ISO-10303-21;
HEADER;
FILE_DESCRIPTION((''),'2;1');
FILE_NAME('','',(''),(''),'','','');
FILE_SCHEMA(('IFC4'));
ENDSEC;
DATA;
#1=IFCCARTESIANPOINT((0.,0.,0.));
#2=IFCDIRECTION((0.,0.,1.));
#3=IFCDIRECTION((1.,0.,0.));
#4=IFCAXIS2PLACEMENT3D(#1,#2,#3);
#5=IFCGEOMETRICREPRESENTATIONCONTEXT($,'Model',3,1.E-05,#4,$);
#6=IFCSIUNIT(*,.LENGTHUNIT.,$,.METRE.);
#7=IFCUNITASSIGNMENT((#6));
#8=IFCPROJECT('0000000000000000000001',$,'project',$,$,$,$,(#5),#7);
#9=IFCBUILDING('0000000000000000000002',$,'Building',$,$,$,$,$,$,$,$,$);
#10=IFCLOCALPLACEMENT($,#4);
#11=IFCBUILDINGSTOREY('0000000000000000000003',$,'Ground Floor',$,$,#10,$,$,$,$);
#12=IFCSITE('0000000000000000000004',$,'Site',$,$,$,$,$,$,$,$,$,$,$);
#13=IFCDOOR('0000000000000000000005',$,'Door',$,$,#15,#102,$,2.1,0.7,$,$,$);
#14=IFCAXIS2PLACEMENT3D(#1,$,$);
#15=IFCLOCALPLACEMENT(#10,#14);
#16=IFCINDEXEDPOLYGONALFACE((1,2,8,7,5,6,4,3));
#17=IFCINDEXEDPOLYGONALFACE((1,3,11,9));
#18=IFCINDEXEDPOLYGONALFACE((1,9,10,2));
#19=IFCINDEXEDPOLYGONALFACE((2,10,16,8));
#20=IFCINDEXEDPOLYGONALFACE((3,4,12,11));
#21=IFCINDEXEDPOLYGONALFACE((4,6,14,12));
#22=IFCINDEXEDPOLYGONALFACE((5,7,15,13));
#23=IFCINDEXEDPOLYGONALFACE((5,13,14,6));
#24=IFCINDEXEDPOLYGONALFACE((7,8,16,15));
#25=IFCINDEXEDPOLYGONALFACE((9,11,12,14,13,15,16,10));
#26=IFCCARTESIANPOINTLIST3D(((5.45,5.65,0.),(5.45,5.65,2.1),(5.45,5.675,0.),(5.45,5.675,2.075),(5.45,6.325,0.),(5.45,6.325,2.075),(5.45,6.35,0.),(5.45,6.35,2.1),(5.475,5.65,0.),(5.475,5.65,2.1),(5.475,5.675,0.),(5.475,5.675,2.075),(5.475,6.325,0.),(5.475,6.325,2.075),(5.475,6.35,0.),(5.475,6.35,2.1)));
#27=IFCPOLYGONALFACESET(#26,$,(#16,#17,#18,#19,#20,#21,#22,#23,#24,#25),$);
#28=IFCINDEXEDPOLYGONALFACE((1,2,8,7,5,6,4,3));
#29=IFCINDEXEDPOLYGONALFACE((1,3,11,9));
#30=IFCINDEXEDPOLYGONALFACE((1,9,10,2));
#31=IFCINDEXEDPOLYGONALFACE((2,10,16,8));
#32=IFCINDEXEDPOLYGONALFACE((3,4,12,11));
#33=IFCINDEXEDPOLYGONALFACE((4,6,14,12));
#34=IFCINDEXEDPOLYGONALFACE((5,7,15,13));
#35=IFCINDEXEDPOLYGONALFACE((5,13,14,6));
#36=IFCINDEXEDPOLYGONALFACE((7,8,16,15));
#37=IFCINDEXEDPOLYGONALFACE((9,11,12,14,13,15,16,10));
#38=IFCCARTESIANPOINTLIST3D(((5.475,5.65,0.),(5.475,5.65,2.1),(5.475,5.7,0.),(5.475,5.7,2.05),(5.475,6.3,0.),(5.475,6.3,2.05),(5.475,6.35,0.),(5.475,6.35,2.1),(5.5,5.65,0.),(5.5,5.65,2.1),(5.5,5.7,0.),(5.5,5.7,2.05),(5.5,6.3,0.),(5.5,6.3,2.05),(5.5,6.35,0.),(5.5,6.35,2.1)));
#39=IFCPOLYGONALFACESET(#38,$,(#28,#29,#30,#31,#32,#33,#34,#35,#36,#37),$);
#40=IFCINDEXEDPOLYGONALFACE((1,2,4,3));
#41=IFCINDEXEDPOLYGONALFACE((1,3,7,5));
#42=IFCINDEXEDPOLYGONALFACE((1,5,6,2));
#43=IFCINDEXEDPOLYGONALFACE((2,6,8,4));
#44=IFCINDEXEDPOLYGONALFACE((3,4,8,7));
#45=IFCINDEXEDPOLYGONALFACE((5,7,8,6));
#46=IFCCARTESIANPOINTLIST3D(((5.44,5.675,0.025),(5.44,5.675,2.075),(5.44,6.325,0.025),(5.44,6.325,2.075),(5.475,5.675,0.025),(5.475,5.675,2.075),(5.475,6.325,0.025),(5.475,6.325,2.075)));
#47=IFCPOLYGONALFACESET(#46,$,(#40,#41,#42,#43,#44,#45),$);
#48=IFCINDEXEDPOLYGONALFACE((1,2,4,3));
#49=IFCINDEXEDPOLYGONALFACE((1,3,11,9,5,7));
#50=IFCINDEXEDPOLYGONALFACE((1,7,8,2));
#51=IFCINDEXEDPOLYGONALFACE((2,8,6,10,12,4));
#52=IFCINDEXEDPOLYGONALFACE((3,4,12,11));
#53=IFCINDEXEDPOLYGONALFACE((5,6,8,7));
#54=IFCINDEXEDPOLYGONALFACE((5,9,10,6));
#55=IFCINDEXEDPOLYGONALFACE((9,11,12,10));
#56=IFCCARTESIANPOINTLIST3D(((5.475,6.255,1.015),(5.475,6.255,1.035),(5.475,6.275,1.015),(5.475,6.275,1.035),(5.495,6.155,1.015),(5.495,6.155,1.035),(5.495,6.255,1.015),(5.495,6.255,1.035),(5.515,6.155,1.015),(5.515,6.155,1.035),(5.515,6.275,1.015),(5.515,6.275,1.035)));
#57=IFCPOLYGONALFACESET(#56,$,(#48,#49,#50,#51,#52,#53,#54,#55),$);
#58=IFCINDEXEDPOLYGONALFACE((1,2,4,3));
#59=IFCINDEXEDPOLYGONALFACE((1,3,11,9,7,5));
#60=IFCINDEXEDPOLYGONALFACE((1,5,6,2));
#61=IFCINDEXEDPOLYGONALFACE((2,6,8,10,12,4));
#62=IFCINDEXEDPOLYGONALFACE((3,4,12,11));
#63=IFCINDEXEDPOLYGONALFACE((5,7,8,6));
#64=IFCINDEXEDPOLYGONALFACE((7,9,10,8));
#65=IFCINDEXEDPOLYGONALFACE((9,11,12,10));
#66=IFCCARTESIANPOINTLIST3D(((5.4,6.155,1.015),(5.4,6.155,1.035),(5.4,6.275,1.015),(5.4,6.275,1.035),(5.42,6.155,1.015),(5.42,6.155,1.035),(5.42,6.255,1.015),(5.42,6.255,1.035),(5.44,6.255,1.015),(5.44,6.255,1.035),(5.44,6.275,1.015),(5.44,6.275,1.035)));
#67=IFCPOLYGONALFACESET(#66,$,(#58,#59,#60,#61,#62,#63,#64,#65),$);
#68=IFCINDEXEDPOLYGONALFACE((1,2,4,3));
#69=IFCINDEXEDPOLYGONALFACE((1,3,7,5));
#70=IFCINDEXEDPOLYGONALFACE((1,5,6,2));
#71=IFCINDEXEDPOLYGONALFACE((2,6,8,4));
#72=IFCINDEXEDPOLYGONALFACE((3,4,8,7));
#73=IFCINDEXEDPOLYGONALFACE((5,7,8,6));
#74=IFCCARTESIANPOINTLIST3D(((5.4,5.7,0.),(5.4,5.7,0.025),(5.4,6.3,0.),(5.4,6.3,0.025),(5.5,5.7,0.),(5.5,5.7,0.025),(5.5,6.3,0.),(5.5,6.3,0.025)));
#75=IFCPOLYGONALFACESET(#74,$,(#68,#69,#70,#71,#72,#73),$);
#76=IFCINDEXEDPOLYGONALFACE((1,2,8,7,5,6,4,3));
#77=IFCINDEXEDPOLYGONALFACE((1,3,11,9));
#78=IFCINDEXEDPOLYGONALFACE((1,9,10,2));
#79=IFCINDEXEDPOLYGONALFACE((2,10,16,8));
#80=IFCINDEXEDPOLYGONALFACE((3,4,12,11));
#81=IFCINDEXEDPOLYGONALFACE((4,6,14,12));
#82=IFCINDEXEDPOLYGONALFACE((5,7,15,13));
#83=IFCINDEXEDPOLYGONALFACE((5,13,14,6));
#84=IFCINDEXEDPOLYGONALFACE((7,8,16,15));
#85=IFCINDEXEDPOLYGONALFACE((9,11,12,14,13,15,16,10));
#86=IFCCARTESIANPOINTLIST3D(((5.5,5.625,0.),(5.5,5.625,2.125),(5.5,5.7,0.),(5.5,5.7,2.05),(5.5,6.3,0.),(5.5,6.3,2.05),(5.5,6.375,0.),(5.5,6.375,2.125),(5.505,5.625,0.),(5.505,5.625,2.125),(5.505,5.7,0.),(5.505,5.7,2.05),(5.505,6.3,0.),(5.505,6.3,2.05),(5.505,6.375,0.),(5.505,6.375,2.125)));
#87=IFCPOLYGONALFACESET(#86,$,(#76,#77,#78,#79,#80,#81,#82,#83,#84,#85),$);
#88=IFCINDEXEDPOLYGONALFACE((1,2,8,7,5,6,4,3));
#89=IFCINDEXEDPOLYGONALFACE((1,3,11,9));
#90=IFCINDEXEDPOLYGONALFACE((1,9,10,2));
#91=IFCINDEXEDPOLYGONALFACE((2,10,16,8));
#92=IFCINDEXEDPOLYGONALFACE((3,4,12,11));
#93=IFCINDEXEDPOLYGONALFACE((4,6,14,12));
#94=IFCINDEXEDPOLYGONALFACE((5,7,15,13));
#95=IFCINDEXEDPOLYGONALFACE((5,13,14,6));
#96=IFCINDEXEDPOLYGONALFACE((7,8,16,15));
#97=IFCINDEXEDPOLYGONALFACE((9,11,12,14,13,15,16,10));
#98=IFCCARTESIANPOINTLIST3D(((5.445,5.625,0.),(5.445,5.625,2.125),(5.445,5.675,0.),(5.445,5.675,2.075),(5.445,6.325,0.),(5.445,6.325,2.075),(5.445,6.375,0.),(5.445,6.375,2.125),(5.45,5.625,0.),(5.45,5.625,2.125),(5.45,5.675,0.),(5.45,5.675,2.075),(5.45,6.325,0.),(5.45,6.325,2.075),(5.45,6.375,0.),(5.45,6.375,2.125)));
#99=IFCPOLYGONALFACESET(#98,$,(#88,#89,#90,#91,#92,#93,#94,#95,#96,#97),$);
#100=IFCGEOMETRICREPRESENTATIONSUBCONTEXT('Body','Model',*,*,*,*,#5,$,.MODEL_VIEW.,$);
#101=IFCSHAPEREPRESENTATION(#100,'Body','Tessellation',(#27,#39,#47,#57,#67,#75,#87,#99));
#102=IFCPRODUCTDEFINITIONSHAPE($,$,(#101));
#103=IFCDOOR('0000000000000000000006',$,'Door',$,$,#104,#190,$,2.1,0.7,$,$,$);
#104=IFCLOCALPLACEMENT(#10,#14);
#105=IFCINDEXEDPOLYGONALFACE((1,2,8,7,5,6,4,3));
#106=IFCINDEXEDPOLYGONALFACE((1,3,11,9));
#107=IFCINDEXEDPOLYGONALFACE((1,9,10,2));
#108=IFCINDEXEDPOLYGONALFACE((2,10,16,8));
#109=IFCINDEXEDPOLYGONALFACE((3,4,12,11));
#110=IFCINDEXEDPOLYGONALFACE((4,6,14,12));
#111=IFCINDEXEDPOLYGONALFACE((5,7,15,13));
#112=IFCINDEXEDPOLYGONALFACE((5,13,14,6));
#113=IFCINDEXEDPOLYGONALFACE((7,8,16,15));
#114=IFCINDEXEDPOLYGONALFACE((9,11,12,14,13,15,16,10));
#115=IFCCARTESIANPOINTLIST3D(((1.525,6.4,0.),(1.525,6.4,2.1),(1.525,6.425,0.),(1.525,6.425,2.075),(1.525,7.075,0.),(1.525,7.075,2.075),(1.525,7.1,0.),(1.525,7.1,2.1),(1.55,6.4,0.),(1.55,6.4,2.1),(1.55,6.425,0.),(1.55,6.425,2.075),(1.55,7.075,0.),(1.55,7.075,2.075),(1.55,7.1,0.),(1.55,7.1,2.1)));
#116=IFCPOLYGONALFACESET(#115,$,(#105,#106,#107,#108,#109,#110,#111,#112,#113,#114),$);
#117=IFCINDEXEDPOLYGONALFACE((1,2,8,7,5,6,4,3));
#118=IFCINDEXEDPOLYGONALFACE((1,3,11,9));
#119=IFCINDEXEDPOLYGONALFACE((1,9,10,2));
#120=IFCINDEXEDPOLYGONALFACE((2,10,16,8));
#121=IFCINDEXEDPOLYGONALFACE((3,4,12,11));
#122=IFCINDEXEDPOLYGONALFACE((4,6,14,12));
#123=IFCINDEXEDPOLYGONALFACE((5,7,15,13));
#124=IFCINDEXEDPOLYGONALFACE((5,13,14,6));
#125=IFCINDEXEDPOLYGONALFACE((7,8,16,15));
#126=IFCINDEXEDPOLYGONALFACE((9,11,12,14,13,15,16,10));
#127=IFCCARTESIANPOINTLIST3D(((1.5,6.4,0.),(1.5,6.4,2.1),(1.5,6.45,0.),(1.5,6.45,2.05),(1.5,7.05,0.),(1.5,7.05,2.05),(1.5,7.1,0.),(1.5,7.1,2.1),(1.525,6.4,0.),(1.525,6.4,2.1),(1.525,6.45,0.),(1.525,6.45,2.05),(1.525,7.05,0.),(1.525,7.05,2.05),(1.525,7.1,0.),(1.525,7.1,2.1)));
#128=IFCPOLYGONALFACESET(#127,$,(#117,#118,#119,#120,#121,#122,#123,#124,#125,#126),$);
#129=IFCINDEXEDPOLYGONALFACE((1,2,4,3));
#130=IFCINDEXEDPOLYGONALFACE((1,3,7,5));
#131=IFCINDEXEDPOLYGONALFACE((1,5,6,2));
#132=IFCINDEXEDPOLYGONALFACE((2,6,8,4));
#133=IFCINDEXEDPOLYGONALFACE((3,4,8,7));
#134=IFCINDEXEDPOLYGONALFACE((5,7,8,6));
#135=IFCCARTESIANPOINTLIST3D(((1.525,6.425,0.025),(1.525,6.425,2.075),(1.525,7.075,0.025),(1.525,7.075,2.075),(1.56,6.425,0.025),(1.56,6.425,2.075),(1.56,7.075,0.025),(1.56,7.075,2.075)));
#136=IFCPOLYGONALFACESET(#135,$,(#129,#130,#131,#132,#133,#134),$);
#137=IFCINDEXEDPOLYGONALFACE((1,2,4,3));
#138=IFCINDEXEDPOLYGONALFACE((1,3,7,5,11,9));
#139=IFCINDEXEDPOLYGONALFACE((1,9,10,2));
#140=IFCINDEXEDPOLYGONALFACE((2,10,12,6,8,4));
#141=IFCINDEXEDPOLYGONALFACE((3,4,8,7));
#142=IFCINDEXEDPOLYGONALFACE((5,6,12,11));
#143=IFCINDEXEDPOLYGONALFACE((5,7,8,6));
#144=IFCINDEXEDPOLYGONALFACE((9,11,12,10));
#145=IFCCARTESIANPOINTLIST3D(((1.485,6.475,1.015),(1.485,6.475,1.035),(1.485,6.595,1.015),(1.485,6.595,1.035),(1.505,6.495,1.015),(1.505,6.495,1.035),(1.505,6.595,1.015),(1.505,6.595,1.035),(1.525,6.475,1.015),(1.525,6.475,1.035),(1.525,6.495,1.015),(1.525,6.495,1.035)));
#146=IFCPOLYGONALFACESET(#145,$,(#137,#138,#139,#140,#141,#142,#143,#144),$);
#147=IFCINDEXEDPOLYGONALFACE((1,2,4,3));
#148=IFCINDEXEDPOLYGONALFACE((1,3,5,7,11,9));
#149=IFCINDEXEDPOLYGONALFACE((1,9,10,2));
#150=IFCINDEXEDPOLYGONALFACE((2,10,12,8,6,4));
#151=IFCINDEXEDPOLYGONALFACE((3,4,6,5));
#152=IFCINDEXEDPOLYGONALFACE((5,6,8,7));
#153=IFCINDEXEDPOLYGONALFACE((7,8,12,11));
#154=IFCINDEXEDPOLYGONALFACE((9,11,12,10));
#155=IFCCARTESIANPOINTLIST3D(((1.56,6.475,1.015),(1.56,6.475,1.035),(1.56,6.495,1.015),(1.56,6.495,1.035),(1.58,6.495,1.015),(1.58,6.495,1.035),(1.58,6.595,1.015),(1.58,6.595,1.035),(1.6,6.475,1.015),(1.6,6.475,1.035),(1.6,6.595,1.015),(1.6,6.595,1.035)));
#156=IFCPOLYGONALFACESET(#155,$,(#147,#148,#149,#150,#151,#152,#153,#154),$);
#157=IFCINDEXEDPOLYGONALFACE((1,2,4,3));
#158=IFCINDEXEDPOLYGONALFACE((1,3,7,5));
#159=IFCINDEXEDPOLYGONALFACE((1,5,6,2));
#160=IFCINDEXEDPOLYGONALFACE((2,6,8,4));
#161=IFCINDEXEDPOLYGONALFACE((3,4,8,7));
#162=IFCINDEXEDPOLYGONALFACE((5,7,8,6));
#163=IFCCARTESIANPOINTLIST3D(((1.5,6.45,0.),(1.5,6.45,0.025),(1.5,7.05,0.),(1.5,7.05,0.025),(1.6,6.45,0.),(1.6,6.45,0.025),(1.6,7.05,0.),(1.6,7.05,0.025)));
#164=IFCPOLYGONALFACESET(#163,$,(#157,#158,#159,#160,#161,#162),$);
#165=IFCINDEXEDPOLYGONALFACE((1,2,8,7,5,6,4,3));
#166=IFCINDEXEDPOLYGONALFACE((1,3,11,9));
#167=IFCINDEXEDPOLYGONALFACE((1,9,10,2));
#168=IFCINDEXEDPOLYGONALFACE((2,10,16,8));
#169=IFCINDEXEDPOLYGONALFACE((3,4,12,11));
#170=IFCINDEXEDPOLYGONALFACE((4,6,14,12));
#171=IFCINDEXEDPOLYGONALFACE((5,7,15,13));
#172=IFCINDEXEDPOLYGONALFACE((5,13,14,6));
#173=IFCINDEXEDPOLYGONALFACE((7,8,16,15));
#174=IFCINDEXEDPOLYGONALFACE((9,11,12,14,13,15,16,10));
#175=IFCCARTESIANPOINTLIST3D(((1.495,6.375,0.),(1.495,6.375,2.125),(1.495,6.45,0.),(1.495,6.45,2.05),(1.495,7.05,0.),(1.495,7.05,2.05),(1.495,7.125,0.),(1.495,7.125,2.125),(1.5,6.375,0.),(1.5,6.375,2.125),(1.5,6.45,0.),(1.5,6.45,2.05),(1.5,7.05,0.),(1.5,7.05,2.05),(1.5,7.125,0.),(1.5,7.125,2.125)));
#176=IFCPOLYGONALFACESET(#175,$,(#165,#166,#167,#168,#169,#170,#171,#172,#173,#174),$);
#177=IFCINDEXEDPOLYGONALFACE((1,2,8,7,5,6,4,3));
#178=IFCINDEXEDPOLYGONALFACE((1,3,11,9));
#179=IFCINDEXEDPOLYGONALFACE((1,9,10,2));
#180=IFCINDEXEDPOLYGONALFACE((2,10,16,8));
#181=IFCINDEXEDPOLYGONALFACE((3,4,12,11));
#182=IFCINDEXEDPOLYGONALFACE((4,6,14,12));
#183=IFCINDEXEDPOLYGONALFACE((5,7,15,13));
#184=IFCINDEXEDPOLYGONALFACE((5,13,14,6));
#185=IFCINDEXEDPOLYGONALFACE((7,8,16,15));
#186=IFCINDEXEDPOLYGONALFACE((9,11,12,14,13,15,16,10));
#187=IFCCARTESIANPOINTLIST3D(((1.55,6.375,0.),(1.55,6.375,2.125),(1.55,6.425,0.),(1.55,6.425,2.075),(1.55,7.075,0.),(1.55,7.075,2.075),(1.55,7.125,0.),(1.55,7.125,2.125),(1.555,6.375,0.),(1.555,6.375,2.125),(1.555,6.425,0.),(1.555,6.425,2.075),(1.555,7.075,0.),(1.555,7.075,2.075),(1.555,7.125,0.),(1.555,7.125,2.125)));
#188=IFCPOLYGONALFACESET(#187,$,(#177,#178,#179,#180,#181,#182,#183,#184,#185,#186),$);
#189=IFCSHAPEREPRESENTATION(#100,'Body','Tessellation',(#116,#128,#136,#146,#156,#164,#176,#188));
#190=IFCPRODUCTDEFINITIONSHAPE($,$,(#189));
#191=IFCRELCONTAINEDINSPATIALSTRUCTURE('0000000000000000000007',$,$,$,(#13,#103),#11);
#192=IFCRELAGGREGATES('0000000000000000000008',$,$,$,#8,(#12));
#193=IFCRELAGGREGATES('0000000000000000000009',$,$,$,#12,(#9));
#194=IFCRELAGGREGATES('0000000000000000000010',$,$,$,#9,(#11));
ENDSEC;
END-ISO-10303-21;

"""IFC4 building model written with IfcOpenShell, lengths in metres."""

from ifc_helpers import new_model, si_unit, frame, origin_with_axes, place, context, subcontext, project, spatial, line, indexed_curve, outline, extrude, element, save


model = new_model("IFC4")

# Units and contexts
model_context = context("Model", 3, precision=1e-05, world=origin_with_axes())
body_context = subcontext(model_context, "Body", "Model", "MODEL_VIEW")
ifc_project = project(units=[si_unit("LENGTHUNIT", "METRE")], contexts=[model_context])

# Site, building, storey
site = spatial("IfcSite", under=ifc_project, Name="Site")
building = spatial("IfcBuilding", under=site, Name="Building")
storey_placement = place(None, origin_with_axes())
storey = spatial("IfcBuildingStorey", under=building, at=storey_placement, Name="Ground Floor")

# Doors
door_1_placement = place(storey_placement, frame((5.5, 5.65, 0.0), z_axis=(0.0, 0.0, 1.0), x_axis=(0.0, 1.0, 0.0)))
element("IfcDoor", 1, at=door_1_placement, inside=storey, Name="Door", OverallHeight=2.1, OverallWidth=0.7, context=body_context, shape_type="SweptSolid", body=[
    extrude(outline(indexed_curve([(0.0, 0.0), (0.0, 2.1), (0.7, 2.1), (0.7, 0.0), (0.675, 0.0), (0.675, 2.075), (0.025, 2.075), (0.025, 0.0)], segments=[line(1, 2, 3, 4, 5, 6, 7, 8, 1)])), frame((0.0, 0.025, 0.0), z_axis=(0.0, -1.0, 0.0), x_axis=(1.0, 0.0, 0.0)), (0.0, 0.0, -1.0), 0.025),
    extrude(outline(indexed_curve([(0.0, 0.0), (0.0, 2.1), (0.7, 2.1), (0.7, 0.0), (0.65, 0.0), (0.65, 2.05), (0.05, 2.05), (0.05, 0.0)], segments=[line(1, 2, 3, 4, 5, 6, 7, 8, 1)])), frame((0.0, 0.0, 0.0), z_axis=(0.0, -1.0, 0.0), x_axis=(1.0, 0.0, 0.0)), (0.0, 0.0, -1.0), 0.025),
    extrude(outline(indexed_curve([(0.0, 0.0), (0.65, 0.0), (0.65, 0.035), (0.0, 0.035)], segments=[line(1, 2, 3, 4, 1)])), frame((0.025, 0.025, 0.025), z_axis=(0.0, 0.0, 1.0), x_axis=(1.0, 0.0, 0.0)), (0.0, 0.0, 1.0), 2.05),
    extrude(outline(indexed_curve([(0.0, 0.0), (0.0, -0.04), (-0.12, -0.04), (-0.12, -0.02), (-0.02, -0.02), (-0.02, 0.0)], segments=[line(1, 2, 3, 4, 5, 6, 1)])), frame((0.625, 0.025, 1.015), z_axis=(0.0, 0.0, 1.0), x_axis=(1.0, 0.0, 0.0)), (0.0, 0.0, 1.0), 0.02),
    extrude(outline(indexed_curve([(0.0, 0.0), (0.0, 0.04), (-0.12, 0.04), (-0.12, 0.02), (-0.02, 0.02), (-0.02, 0.0)], segments=[line(1, 2, 3, 4, 5, 6, 1)])), frame((0.625, 0.06, 1.015), z_axis=(0.0, 0.0, 1.0), x_axis=(1.0, 0.0, 0.0)), (0.0, 0.0, 1.0), 0.02),
    extrude(outline(indexed_curve([(0.0, 0.0), (0.6, 0.0), (0.6, 0.1), (0.0, 0.1)], segments=[line(1, 2, 3, 4, 1)])), frame((0.05, 0.0, 0.0), z_axis=(0.0, 0.0, 1.0), x_axis=(1.0, 0.0, 0.0)), (0.0, 0.0, 1.0), 0.025),
    extrude(outline(indexed_curve([(0.0, 0.0), (0.0, 2.125), (0.75, 2.125), (0.75, 0.0), (0.675, 0.0), (0.675, 2.05), (0.075, 2.05), (0.075, 0.0)], segments=[line(1, 2, 3, 4, 5, 6, 7, 8, 1)])), frame((-0.025, -0.005, 0.0), z_axis=(0.0, -1.0, 0.0), x_axis=(1.0, 0.0, 0.0)), (0.0, 0.0, -1.0), 0.005),
    extrude(outline(indexed_curve([(0.0, 0.0), (0.0, 2.125), (0.75, 2.125), (0.75, 0.0), (0.7, 0.0), (0.7, 2.075), (0.05, 2.075), (0.05, 0.0)], segments=[line(1, 2, 3, 4, 5, 6, 7, 8, 1)])), frame((-0.025, 0.05, 0.0), z_axis=(0.0, -1.0, 0.0), x_axis=(1.0, 0.0, 0.0)), (0.0, 0.0, -1.0), 0.005),
])
door_2_placement = place(storey_placement, frame((1.5, 7.1, 0.0), z_axis=(0.0, 0.0, 1.0), x_axis=(0.0, -1.0, 0.0)))
element("IfcDoor", 2, at=door_2_placement, inside=storey, Name="Door", OverallHeight=2.1, OverallWidth=0.7, context=body_context, shape_type="SweptSolid", body=[
    extrude(outline(indexed_curve([(0.0, 0.0), (0.0, 2.1), (0.7, 2.1), (0.7, 0.0), (0.675, 0.0), (0.675, 2.075), (0.025, 2.075), (0.025, 0.0)], segments=[line(1, 2, 3, 4, 5, 6, 7, 8, 1)])), frame((0.0, 0.025, 0.0), z_axis=(0.0, -1.0, 0.0), x_axis=(1.0, 0.0, 0.0)), (0.0, 0.0, -1.0), 0.025),
    extrude(outline(indexed_curve([(0.0, 0.0), (0.0, 2.1), (0.7, 2.1), (0.7, 0.0), (0.65, 0.0), (0.65, 2.05), (0.05, 2.05), (0.05, 0.0)], segments=[line(1, 2, 3, 4, 5, 6, 7, 8, 1)])), frame((0.0, 0.0, 0.0), z_axis=(0.0, -1.0, 0.0), x_axis=(1.0, 0.0, 0.0)), (0.0, 0.0, -1.0), 0.025),
    extrude(outline(indexed_curve([(0.0, 0.0), (0.65, 0.0), (0.65, 0.035), (0.0, 0.035)], segments=[line(1, 2, 3, 4, 1)])), frame((0.025, 0.025, 0.025), z_axis=(0.0, 0.0, 1.0), x_axis=(1.0, 0.0, 0.0)), (0.0, 0.0, 1.0), 2.05),
    extrude(outline(indexed_curve([(0.0, 0.0), (0.0, -0.04), (-0.12, -0.04), (-0.12, -0.02), (-0.02, -0.02), (-0.02, 0.0)], segments=[line(1, 2, 3, 4, 5, 6, 1)])), frame((0.625, 0.025, 1.015), z_axis=(0.0, 0.0, 1.0), x_axis=(1.0, 0.0, 0.0)), (0.0, 0.0, 1.0), 0.02),
    extrude(outline(indexed_curve([(0.0, 0.0), (0.0, 0.04), (-0.12, 0.04), (-0.12, 0.02), (-0.02, 0.02), (-0.02, 0.0)], segments=[line(1, 2, 3, 4, 5, 6, 1)])), frame((0.625, 0.06, 1.015), z_axis=(0.0, 0.0, 1.0), x_axis=(1.0, 0.0, 0.0)), (0.0, 0.0, 1.0), 0.02),
    extrude(outline(indexed_curve([(0.0, 0.0), (0.6, 0.0), (0.6, 0.1), (0.0, 0.1)], segments=[line(1, 2, 3, 4, 1)])), frame((0.05, 0.0, 0.0), z_axis=(0.0, 0.0, 1.0), x_axis=(1.0, 0.0, 0.0)), (0.0, 0.0, 1.0), 0.025),
    extrude(outline(indexed_curve([(0.0, 0.0), (0.0, 2.125), (0.75, 2.125), (0.75, 0.0), (0.675, 0.0), (0.675, 2.05), (0.075, 2.05), (0.075, 0.0)], segments=[line(1, 2, 3, 4, 5, 6, 7, 8, 1)])), frame((-0.025, -0.005, 0.0), z_axis=(0.0, -1.0, 0.0), x_axis=(1.0, 0.0, 0.0)), (0.0, 0.0, -1.0), 0.005),
    extrude(outline(indexed_curve([(0.0, 0.0), (0.0, 2.125), (0.75, 2.125), (0.75, 0.0), (0.7, 0.0), (0.7, 2.075), (0.05, 2.075), (0.05, 0.0)], segments=[line(1, 2, 3, 4, 5, 6, 7, 8, 1)])), frame((-0.025, 0.05, 0.0), z_axis=(0.0, -1.0, 0.0), x_axis=(1.0, 0.0, 0.0)), (0.0, 0.0, -1.0), 0.005),
])

save(model, "model.ifc")
